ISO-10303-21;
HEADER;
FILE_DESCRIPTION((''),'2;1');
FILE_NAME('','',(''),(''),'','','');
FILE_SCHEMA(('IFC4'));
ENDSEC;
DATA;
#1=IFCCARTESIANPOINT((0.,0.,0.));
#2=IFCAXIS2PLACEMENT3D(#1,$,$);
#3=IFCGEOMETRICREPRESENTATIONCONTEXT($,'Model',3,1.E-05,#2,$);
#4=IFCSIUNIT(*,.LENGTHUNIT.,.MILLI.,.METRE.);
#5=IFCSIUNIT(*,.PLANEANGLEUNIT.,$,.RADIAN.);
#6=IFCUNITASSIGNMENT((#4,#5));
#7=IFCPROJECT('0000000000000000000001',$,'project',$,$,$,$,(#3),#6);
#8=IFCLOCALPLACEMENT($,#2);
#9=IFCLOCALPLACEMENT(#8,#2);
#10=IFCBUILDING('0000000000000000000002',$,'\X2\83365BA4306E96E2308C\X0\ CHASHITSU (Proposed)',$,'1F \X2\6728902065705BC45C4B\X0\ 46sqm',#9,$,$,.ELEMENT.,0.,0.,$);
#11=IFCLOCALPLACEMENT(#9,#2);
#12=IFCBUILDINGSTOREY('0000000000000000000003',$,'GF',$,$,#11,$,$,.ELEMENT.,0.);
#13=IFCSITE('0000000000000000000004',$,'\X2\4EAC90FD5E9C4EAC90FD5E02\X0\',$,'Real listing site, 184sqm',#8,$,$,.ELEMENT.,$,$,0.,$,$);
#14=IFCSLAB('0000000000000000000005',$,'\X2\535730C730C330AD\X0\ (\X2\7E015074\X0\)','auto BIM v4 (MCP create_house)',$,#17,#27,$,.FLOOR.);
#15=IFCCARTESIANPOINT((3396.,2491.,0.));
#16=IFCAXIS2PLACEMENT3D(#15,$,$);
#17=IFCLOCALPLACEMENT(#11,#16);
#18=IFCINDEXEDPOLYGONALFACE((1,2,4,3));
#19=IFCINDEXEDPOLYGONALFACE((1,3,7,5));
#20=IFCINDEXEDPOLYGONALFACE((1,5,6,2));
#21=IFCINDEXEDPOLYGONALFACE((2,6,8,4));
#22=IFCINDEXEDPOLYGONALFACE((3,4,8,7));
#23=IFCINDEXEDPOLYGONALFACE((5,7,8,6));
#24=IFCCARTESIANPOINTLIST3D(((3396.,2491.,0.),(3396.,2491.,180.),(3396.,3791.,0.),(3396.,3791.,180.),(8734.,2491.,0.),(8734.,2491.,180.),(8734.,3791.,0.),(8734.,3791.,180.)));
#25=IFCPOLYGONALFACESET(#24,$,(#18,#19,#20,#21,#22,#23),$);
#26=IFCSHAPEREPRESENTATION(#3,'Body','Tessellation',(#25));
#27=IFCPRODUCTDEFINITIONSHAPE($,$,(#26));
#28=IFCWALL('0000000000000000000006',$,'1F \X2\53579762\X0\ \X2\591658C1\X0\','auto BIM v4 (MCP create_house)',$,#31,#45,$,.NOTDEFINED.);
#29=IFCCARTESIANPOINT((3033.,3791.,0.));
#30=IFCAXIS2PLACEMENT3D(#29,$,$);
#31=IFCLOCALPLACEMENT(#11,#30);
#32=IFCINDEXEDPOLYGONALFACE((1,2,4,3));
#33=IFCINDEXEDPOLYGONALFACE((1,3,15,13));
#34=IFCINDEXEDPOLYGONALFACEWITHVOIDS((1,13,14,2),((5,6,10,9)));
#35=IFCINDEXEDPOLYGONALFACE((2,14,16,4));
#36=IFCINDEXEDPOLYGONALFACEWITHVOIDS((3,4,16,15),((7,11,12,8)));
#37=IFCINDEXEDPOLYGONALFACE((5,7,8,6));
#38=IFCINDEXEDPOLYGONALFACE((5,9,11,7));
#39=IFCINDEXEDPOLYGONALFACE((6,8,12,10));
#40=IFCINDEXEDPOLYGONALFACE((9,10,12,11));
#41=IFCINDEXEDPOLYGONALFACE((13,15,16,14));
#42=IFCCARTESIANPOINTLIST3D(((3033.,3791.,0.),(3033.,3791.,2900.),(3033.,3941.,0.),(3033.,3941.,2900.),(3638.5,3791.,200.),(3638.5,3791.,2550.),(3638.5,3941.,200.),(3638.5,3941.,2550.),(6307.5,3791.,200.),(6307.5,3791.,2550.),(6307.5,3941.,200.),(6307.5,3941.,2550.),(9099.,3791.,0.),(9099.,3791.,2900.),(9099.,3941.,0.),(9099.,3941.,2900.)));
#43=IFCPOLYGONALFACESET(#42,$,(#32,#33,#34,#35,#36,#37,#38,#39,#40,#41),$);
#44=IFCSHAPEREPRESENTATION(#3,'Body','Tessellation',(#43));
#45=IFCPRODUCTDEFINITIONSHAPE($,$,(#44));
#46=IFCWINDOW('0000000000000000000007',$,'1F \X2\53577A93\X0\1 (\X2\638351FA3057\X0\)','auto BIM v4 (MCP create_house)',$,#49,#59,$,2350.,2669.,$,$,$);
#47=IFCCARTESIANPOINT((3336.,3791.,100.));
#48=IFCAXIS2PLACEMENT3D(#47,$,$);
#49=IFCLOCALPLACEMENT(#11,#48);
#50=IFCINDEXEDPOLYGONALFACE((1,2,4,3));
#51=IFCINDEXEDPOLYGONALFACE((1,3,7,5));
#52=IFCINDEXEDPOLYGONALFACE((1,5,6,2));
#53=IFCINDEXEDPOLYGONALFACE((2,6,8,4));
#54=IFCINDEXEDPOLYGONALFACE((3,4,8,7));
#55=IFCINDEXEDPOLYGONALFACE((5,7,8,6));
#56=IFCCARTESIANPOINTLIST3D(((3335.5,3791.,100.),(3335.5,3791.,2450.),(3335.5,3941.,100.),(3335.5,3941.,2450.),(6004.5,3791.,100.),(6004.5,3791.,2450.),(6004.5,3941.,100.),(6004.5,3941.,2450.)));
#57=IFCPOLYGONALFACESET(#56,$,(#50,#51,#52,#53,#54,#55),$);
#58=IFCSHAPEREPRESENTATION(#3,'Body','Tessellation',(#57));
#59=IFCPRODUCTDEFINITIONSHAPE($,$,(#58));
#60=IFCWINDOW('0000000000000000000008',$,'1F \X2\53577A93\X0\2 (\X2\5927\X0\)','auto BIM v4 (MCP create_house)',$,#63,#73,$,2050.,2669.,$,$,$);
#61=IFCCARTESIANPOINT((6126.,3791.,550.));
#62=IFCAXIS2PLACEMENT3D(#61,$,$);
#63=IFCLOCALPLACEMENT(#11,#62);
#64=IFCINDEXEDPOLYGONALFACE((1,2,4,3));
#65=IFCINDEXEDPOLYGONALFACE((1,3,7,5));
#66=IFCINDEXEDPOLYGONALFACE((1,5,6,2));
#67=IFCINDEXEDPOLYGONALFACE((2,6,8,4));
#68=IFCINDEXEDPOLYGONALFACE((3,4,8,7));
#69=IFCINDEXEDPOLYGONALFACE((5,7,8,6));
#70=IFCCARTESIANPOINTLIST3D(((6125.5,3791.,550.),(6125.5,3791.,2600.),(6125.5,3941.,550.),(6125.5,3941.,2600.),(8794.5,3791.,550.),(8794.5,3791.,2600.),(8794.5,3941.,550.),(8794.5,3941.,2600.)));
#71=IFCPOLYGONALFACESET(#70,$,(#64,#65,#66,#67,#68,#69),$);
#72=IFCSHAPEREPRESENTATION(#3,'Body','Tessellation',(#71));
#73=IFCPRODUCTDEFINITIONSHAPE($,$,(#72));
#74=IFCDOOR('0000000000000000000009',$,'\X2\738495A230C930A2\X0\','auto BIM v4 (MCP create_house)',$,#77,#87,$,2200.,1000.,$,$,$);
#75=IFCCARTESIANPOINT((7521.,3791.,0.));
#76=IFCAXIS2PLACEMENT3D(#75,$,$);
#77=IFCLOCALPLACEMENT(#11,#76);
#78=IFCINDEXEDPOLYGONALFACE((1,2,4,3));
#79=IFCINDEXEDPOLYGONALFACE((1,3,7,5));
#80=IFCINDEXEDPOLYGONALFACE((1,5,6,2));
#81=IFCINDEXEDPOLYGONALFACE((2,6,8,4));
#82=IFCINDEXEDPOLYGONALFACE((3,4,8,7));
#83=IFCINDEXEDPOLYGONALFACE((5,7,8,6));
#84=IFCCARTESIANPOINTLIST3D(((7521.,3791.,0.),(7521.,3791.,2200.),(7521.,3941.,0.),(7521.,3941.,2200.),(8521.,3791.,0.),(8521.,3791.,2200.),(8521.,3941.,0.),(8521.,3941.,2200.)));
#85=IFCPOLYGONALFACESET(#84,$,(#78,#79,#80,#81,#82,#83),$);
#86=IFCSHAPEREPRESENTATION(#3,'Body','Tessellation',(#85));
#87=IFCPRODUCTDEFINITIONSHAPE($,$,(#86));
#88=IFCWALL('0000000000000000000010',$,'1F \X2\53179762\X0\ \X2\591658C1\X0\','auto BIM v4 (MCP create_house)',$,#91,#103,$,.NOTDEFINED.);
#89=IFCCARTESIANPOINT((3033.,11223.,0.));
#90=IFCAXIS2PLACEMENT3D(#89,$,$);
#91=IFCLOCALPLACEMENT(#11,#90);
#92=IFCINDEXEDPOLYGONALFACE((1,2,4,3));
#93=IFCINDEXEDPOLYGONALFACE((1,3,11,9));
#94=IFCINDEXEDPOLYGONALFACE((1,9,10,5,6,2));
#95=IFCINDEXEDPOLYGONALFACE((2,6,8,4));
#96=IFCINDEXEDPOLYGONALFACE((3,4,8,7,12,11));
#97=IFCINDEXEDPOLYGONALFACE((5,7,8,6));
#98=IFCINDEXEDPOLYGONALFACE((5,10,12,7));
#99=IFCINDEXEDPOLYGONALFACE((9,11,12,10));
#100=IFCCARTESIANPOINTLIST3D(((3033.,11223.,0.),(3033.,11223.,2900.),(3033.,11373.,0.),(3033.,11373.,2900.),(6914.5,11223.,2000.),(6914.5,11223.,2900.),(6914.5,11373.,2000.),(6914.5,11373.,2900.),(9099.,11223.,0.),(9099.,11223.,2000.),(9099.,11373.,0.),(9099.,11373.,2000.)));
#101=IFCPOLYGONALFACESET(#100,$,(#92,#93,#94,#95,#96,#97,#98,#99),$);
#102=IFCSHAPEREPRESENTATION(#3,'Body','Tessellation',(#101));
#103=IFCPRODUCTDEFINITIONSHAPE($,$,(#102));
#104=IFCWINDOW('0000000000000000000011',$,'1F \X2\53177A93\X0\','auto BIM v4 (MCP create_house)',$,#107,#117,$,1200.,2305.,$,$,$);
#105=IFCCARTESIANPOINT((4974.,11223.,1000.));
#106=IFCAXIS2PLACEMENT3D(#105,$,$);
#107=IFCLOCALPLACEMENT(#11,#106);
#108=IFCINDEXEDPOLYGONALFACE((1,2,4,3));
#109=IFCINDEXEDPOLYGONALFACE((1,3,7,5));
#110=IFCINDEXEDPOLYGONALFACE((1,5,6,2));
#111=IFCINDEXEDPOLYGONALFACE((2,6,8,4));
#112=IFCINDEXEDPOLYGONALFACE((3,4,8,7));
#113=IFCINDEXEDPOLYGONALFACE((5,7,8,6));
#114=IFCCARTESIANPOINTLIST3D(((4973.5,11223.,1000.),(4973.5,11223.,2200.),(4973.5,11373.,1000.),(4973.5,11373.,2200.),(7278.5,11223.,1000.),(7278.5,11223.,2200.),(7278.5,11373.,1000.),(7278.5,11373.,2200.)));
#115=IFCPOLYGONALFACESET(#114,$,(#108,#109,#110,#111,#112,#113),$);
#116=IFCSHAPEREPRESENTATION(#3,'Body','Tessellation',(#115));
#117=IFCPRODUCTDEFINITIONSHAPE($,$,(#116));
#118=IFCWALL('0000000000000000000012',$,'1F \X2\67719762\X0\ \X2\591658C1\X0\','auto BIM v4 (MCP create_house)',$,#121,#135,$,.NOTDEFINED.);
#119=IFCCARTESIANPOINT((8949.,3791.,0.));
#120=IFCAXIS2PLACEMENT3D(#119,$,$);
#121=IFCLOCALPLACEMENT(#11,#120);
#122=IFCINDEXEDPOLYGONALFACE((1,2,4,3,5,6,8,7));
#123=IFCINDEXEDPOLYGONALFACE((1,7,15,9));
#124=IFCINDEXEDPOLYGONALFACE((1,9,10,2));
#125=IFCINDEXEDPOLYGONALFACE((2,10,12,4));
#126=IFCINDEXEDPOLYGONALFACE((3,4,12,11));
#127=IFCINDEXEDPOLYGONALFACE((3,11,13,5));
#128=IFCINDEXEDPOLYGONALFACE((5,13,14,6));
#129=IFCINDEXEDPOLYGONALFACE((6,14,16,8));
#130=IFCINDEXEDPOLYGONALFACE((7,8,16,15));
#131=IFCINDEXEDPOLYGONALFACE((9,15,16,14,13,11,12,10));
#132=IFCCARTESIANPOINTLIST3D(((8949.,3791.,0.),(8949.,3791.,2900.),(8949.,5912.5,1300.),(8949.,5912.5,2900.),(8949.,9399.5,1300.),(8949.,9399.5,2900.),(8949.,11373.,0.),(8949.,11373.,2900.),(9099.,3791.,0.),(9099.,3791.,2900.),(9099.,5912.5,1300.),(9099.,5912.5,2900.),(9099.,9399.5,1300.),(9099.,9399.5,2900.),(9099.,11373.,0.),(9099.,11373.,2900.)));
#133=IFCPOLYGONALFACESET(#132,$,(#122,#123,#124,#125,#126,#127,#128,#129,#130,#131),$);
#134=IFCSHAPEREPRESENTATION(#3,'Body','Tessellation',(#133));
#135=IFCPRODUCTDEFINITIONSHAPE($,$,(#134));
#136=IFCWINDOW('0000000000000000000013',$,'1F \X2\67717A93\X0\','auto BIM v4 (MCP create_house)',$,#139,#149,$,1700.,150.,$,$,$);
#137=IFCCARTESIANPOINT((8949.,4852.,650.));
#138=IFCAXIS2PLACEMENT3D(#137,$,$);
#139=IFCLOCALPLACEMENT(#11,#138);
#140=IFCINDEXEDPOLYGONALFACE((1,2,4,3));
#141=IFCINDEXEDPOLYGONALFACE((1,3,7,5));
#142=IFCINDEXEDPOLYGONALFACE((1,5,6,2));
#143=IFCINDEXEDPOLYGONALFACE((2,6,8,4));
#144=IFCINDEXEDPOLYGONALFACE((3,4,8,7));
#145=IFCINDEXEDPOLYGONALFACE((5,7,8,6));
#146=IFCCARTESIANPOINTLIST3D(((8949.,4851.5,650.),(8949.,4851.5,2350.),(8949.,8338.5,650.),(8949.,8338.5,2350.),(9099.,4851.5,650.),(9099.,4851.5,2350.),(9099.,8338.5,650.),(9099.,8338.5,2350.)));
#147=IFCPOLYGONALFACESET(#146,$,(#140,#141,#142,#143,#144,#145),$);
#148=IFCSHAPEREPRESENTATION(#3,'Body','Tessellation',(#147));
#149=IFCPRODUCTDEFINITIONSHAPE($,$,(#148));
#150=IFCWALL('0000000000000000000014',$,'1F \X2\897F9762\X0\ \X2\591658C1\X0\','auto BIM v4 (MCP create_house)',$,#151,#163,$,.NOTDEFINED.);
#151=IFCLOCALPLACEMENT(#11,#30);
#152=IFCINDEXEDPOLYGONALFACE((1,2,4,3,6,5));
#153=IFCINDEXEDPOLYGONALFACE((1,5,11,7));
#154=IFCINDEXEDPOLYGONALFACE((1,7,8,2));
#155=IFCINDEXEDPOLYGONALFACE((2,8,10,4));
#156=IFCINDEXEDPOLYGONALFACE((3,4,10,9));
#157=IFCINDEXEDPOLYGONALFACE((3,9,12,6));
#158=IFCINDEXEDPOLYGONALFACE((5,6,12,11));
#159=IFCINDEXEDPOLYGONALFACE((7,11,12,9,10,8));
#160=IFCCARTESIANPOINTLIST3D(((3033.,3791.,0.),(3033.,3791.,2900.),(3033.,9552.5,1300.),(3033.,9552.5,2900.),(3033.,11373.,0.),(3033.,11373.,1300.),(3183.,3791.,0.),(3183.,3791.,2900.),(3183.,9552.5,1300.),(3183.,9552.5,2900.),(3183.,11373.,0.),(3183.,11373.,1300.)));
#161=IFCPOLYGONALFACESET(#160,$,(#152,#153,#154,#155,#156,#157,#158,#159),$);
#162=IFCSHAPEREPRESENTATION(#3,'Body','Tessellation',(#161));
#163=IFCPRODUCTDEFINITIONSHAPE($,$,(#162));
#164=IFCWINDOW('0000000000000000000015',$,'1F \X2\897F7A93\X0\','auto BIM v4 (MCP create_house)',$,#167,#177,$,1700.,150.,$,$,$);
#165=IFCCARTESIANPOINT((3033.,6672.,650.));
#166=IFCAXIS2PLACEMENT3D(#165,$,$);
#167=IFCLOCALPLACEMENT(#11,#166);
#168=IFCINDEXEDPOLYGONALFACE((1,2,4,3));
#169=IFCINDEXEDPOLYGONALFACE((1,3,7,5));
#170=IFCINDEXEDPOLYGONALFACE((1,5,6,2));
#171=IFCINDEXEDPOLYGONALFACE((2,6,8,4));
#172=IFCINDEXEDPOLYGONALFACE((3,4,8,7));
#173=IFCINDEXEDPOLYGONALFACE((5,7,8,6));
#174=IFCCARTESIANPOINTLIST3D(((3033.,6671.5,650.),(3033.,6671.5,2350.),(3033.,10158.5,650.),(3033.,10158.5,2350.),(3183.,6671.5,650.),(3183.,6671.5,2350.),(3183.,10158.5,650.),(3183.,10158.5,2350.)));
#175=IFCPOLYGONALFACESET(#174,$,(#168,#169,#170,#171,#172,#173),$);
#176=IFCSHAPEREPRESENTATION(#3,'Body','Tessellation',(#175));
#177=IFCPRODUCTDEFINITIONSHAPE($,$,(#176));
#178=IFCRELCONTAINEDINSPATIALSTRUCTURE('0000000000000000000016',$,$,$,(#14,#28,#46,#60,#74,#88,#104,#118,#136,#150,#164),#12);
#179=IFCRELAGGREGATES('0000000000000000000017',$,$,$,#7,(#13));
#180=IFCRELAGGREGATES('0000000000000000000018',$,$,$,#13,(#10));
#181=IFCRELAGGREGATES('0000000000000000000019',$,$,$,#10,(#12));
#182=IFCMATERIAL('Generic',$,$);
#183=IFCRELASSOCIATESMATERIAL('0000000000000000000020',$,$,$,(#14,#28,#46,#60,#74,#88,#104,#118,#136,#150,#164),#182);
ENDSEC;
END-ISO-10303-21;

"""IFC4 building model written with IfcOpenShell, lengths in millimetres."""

from ifc_helpers import new_model, si_unit, frame, frame_2d, origin, place, context, project, spatial, rectangle, extrude, material, element, fill, save


model = new_model("IFC4")

# Units and contexts
model_context = context("Model", 3, precision=1e-05, world=origin())
ifc_project = project(units=[si_unit("LENGTHUNIT", "METRE", prefix="MILLI"), si_unit("PLANEANGLEUNIT", "RADIAN")], contexts=[model_context])

# Site, building, storey
site_placement = place(None, origin())
site = spatial("IfcSite", under=ifc_project, at=site_placement, Name="京都府京都市", ObjectType="Real listing site, 184sqm", CompositionType="ELEMENT", RefElevation=0.0)
building_placement = place(site_placement, origin())
building = spatial("IfcBuilding", under=site, at=building_placement, Name="茶室の離れ CHASHITSU (Proposed)", ObjectType="1F 木造数寄屋 46sqm", CompositionType="ELEMENT", ElevationOfRefHeight=0.0, ElevationOfTerrain=0.0)
storey_placement = place(building_placement, origin())
storey = spatial("IfcBuildingStorey", under=building, at=storey_placement, Name="GF", CompositionType="ELEMENT", Elevation=0.0)

# Slab
ifc_material = material(Name="Generic")
slab_1_placement = place(storey_placement, frame((3396.0, 2491.0, 0.0)))
element("IfcSlab", 1, at=slab_1_placement, inside=storey, material=ifc_material, Name="南デッキ (縁側)", Description="auto BIM v4 (MCP create_house)", PredefinedType="FLOOR", context=model_context, shape_type="SweptSolid", body=[
    extrude(rectangle(XDim=5338.0, YDim=1300.0, at=frame_2d((2669.0, 650.0))), frame((3396.0, 2491.0, 0.0)), (0.0, 0.0, 1.0), 180.0),
])

# Wall, openings, windows, door
wall_1_placement = place(storey_placement, frame((3033.0, 3791.0, 0.0)))
wall_1 = element("IfcWall", 2, at=wall_1_placement, inside=storey, material=ifc_material, Name="1F 南面 外壁", Description="auto BIM v4 (MCP create_house)", PredefinedType="NOTDEFINED", context=model_context, shape_type="SweptSolid", body=[
    extrude(rectangle(XDim=6066.0, YDim=150.0, at=frame_2d((3033.0, 75.0))), frame((3033.0, 3791.0, 0.0)), (0.0, 0.0, 1.0), 2900.0),
])
opening_1_placement = place(storey_placement, frame((3336.0, 3791.0, 100.0)))
opening_1 = element("IfcOpeningElement", 3, at=opening_1_placement, cuts=wall_1, PredefinedType="NOTDEFINED", context=model_context, shape_type="SweptSolid", body=[
    extrude(rectangle(XDim=2669.0, YDim=150.0, at=frame_2d((1334.0, 75.0))), frame((3336.0, 3791.0, 100.0)), (0.0, 0.0, 1.0), 2350.0),
])
opening_2_placement = place(storey_placement, frame((6126.0, 3791.0, 550.0)))
opening_2 = element("IfcOpeningElement", 4, at=opening_2_placement, cuts=wall_1, PredefinedType="NOTDEFINED", context=model_context, shape_type="SweptSolid", body=[
    extrude(rectangle(XDim=2669.0, YDim=150.0, at=frame_2d((1334.0, 75.0))), frame((6126.0, 3791.0, 550.0)), (0.0, 0.0, 1.0), 2050.0),
])
opening_3_placement = place(storey_placement, frame((7521.0, 3791.0, 0.0)))
opening_3 = element("IfcOpeningElement", 5, at=opening_3_placement, cuts=wall_1, PredefinedType="NOTDEFINED", context=model_context, shape_type="SweptSolid", body=[
    extrude(rectangle(XDim=1000.0, YDim=150.0, at=frame_2d((500.0, 75.0))), frame((7521.0, 3791.0, 0.0)), (0.0, 0.0, 1.0), 2200.0),
])
window_1_placement = place(storey_placement, frame((3336.0, 3791.0, 100.0)))
window_1 = element("IfcWindow", 6, at=window_1_placement, inside=storey, material=ifc_material, Name="1F 南窓1 (掃出し)", Description="auto BIM v4 (MCP create_house)", OverallHeight=2350.0, OverallWidth=2669.0, context=model_context, shape_type="SweptSolid", body=[
    extrude(rectangle(XDim=2669.0, YDim=150.0, at=frame_2d((1334.0, 75.0))), frame((3336.0, 3791.0, 100.0)), (0.0, 0.0, 1.0), 2350.0),
])
fill(opening_1, window_1)
window_2_placement = place(storey_placement, frame((6126.0, 3791.0, 550.0)))
window_2 = element("IfcWindow", 7, at=window_2_placement, inside=storey, material=ifc_material, Name="1F 南窓2 (大)", Description="auto BIM v4 (MCP create_house)", OverallHeight=2050.0, OverallWidth=2669.0, context=model_context, shape_type="SweptSolid", body=[
    extrude(rectangle(XDim=2669.0, YDim=150.0, at=frame_2d((1334.0, 75.0))), frame((6126.0, 3791.0, 550.0)), (0.0, 0.0, 1.0), 2050.0),
])
fill(opening_2, window_2)
door_placement = place(storey_placement, frame((7521.0, 3791.0, 0.0)))
door = element("IfcDoor", 8, at=door_placement, inside=storey, material=ifc_material, Name="玄関ドア", Description="auto BIM v4 (MCP create_house)", OverallHeight=2200.0, OverallWidth=1000.0, context=model_context, shape_type="SweptSolid", body=[
    extrude(rectangle(XDim=1000.0, YDim=150.0, at=frame_2d((500.0, 75.0))), frame((7521.0, 3791.0, 0.0)), (0.0, 0.0, 1.0), 2200.0),
])
fill(opening_3, door)

# Walls, openings, windows
wall_2_placement = place(storey_placement, frame((3033.0, 11223.0, 0.0)))
wall_2 = element("IfcWall", 9, at=wall_2_placement, inside=storey, material=ifc_material, Name="1F 北面 外壁", Description="auto BIM v4 (MCP create_house)", PredefinedType="NOTDEFINED", context=model_context, shape_type="SweptSolid", body=[
    extrude(rectangle(XDim=6066.0, YDim=150.0, at=frame_2d((3033.0, 75.0))), frame((3033.0, 11223.0, 0.0)), (0.0, 0.0, 1.0), 2900.0),
])
opening_4_placement = place(storey_placement, frame((4974.0, 11223.0, 1000.0)))
opening_4 = element("IfcOpeningElement", 10, at=opening_4_placement, cuts=wall_2, PredefinedType="NOTDEFINED", context=model_context, shape_type="SweptSolid", body=[
    extrude(rectangle(XDim=2305.0, YDim=150.0, at=frame_2d((1152.0, 75.0))), frame((4974.0, 11223.0, 1000.0)), (0.0, 0.0, 1.0), 1200.0),
])
window_3_placement = place(storey_placement, frame((4974.0, 11223.0, 1000.0)))
window_3 = element("IfcWindow", 11, at=window_3_placement, inside=storey, material=ifc_material, Name="1F 北窓", Description="auto BIM v4 (MCP create_house)", OverallHeight=1200.0, OverallWidth=2305.0, context=model_context, shape_type="SweptSolid", body=[
    extrude(rectangle(XDim=2305.0, YDim=150.0, at=frame_2d((1152.0, 75.0))), frame((4974.0, 11223.0, 1000.0)), (0.0, 0.0, 1.0), 1200.0),
])
fill(opening_4, window_3)
wall_3_placement = place(storey_placement, frame((8949.0, 3791.0, 0.0)))
wall_3 = element("IfcWall", 12, at=wall_3_placement, inside=storey, material=ifc_material, Name="1F 東面 外壁", Description="auto BIM v4 (MCP create_house)", PredefinedType="NOTDEFINED", context=model_context, shape_type="SweptSolid", body=[
    extrude(rectangle(XDim=150.0, YDim=7582.0, at=frame_2d((75.0, 3791.0))), frame((8949.0, 3791.0, 0.0)), (0.0, 0.0, 1.0), 2900.0),
])
opening_5_placement = place(storey_placement, frame((8949.0, 4852.0, 650.0)))
opening_5 = element("IfcOpeningElement", 13, at=opening_5_placement, cuts=wall_3, PredefinedType="NOTDEFINED", context=model_context, shape_type="SweptSolid", body=[
    extrude(rectangle(XDim=150.0, YDim=3487.0, at=frame_2d((75.0, 1743.0))), frame((8949.0, 4852.0, 650.0)), (0.0, 0.0, 1.0), 1700.0),
])
window_4_placement = place(storey_placement, frame((8949.0, 4852.0, 650.0)))
window_4 = element("IfcWindow", 14, at=window_4_placement, inside=storey, material=ifc_material, Name="1F 東窓", Description="auto BIM v4 (MCP create_house)", OverallHeight=1700.0, OverallWidth=150.0, context=model_context, shape_type="SweptSolid", body=[
    extrude(rectangle(XDim=150.0, YDim=3487.0, at=frame_2d((75.0, 1743.0))), frame((8949.0, 4852.0, 650.0)), (0.0, 0.0, 1.0), 1700.0),
])
fill(opening_5, window_4)
wall_4_placement = place(storey_placement, frame((3033.0, 3791.0, 0.0)))
wall_4 = element("IfcWall", 15, at=wall_4_placement, inside=storey, material=ifc_material, Name="1F 西面 外壁", Description="auto BIM v4 (MCP create_house)", PredefinedType="NOTDEFINED", context=model_context, shape_type="SweptSolid", body=[
    extrude(rectangle(XDim=150.0, YDim=7582.0, at=frame_2d((75.0, 3791.0))), frame((3033.0, 3791.0, 0.0)), (0.0, 0.0, 1.0), 2900.0),
])
opening_6_placement = place(storey_placement, frame((3033.0, 6672.0, 650.0)))
opening_6 = element("IfcOpeningElement", 16, at=opening_6_placement, cuts=wall_4, PredefinedType="NOTDEFINED", context=model_context, shape_type="SweptSolid", body=[
    extrude(rectangle(XDim=150.0, YDim=3487.0, at=frame_2d((75.0, 1743.0))), frame((3033.0, 6672.0, 650.0)), (0.0, 0.0, 1.0), 1700.0),
])
window_5_placement = place(storey_placement, frame((3033.0, 6672.0, 650.0)))
window_5 = element("IfcWindow", 17, at=window_5_placement, inside=storey, material=ifc_material, Name="1F 西窓", Description="auto BIM v4 (MCP create_house)", OverallHeight=1700.0, OverallWidth=150.0, context=model_context, shape_type="SweptSolid", body=[
    extrude(rectangle(XDim=150.0, YDim=3487.0, at=frame_2d((75.0, 1743.0))), frame((3033.0, 6672.0, 650.0)), (0.0, 0.0, 1.0), 1700.0),
])
fill(opening_6, window_5)

save(model, "model.ifc")
